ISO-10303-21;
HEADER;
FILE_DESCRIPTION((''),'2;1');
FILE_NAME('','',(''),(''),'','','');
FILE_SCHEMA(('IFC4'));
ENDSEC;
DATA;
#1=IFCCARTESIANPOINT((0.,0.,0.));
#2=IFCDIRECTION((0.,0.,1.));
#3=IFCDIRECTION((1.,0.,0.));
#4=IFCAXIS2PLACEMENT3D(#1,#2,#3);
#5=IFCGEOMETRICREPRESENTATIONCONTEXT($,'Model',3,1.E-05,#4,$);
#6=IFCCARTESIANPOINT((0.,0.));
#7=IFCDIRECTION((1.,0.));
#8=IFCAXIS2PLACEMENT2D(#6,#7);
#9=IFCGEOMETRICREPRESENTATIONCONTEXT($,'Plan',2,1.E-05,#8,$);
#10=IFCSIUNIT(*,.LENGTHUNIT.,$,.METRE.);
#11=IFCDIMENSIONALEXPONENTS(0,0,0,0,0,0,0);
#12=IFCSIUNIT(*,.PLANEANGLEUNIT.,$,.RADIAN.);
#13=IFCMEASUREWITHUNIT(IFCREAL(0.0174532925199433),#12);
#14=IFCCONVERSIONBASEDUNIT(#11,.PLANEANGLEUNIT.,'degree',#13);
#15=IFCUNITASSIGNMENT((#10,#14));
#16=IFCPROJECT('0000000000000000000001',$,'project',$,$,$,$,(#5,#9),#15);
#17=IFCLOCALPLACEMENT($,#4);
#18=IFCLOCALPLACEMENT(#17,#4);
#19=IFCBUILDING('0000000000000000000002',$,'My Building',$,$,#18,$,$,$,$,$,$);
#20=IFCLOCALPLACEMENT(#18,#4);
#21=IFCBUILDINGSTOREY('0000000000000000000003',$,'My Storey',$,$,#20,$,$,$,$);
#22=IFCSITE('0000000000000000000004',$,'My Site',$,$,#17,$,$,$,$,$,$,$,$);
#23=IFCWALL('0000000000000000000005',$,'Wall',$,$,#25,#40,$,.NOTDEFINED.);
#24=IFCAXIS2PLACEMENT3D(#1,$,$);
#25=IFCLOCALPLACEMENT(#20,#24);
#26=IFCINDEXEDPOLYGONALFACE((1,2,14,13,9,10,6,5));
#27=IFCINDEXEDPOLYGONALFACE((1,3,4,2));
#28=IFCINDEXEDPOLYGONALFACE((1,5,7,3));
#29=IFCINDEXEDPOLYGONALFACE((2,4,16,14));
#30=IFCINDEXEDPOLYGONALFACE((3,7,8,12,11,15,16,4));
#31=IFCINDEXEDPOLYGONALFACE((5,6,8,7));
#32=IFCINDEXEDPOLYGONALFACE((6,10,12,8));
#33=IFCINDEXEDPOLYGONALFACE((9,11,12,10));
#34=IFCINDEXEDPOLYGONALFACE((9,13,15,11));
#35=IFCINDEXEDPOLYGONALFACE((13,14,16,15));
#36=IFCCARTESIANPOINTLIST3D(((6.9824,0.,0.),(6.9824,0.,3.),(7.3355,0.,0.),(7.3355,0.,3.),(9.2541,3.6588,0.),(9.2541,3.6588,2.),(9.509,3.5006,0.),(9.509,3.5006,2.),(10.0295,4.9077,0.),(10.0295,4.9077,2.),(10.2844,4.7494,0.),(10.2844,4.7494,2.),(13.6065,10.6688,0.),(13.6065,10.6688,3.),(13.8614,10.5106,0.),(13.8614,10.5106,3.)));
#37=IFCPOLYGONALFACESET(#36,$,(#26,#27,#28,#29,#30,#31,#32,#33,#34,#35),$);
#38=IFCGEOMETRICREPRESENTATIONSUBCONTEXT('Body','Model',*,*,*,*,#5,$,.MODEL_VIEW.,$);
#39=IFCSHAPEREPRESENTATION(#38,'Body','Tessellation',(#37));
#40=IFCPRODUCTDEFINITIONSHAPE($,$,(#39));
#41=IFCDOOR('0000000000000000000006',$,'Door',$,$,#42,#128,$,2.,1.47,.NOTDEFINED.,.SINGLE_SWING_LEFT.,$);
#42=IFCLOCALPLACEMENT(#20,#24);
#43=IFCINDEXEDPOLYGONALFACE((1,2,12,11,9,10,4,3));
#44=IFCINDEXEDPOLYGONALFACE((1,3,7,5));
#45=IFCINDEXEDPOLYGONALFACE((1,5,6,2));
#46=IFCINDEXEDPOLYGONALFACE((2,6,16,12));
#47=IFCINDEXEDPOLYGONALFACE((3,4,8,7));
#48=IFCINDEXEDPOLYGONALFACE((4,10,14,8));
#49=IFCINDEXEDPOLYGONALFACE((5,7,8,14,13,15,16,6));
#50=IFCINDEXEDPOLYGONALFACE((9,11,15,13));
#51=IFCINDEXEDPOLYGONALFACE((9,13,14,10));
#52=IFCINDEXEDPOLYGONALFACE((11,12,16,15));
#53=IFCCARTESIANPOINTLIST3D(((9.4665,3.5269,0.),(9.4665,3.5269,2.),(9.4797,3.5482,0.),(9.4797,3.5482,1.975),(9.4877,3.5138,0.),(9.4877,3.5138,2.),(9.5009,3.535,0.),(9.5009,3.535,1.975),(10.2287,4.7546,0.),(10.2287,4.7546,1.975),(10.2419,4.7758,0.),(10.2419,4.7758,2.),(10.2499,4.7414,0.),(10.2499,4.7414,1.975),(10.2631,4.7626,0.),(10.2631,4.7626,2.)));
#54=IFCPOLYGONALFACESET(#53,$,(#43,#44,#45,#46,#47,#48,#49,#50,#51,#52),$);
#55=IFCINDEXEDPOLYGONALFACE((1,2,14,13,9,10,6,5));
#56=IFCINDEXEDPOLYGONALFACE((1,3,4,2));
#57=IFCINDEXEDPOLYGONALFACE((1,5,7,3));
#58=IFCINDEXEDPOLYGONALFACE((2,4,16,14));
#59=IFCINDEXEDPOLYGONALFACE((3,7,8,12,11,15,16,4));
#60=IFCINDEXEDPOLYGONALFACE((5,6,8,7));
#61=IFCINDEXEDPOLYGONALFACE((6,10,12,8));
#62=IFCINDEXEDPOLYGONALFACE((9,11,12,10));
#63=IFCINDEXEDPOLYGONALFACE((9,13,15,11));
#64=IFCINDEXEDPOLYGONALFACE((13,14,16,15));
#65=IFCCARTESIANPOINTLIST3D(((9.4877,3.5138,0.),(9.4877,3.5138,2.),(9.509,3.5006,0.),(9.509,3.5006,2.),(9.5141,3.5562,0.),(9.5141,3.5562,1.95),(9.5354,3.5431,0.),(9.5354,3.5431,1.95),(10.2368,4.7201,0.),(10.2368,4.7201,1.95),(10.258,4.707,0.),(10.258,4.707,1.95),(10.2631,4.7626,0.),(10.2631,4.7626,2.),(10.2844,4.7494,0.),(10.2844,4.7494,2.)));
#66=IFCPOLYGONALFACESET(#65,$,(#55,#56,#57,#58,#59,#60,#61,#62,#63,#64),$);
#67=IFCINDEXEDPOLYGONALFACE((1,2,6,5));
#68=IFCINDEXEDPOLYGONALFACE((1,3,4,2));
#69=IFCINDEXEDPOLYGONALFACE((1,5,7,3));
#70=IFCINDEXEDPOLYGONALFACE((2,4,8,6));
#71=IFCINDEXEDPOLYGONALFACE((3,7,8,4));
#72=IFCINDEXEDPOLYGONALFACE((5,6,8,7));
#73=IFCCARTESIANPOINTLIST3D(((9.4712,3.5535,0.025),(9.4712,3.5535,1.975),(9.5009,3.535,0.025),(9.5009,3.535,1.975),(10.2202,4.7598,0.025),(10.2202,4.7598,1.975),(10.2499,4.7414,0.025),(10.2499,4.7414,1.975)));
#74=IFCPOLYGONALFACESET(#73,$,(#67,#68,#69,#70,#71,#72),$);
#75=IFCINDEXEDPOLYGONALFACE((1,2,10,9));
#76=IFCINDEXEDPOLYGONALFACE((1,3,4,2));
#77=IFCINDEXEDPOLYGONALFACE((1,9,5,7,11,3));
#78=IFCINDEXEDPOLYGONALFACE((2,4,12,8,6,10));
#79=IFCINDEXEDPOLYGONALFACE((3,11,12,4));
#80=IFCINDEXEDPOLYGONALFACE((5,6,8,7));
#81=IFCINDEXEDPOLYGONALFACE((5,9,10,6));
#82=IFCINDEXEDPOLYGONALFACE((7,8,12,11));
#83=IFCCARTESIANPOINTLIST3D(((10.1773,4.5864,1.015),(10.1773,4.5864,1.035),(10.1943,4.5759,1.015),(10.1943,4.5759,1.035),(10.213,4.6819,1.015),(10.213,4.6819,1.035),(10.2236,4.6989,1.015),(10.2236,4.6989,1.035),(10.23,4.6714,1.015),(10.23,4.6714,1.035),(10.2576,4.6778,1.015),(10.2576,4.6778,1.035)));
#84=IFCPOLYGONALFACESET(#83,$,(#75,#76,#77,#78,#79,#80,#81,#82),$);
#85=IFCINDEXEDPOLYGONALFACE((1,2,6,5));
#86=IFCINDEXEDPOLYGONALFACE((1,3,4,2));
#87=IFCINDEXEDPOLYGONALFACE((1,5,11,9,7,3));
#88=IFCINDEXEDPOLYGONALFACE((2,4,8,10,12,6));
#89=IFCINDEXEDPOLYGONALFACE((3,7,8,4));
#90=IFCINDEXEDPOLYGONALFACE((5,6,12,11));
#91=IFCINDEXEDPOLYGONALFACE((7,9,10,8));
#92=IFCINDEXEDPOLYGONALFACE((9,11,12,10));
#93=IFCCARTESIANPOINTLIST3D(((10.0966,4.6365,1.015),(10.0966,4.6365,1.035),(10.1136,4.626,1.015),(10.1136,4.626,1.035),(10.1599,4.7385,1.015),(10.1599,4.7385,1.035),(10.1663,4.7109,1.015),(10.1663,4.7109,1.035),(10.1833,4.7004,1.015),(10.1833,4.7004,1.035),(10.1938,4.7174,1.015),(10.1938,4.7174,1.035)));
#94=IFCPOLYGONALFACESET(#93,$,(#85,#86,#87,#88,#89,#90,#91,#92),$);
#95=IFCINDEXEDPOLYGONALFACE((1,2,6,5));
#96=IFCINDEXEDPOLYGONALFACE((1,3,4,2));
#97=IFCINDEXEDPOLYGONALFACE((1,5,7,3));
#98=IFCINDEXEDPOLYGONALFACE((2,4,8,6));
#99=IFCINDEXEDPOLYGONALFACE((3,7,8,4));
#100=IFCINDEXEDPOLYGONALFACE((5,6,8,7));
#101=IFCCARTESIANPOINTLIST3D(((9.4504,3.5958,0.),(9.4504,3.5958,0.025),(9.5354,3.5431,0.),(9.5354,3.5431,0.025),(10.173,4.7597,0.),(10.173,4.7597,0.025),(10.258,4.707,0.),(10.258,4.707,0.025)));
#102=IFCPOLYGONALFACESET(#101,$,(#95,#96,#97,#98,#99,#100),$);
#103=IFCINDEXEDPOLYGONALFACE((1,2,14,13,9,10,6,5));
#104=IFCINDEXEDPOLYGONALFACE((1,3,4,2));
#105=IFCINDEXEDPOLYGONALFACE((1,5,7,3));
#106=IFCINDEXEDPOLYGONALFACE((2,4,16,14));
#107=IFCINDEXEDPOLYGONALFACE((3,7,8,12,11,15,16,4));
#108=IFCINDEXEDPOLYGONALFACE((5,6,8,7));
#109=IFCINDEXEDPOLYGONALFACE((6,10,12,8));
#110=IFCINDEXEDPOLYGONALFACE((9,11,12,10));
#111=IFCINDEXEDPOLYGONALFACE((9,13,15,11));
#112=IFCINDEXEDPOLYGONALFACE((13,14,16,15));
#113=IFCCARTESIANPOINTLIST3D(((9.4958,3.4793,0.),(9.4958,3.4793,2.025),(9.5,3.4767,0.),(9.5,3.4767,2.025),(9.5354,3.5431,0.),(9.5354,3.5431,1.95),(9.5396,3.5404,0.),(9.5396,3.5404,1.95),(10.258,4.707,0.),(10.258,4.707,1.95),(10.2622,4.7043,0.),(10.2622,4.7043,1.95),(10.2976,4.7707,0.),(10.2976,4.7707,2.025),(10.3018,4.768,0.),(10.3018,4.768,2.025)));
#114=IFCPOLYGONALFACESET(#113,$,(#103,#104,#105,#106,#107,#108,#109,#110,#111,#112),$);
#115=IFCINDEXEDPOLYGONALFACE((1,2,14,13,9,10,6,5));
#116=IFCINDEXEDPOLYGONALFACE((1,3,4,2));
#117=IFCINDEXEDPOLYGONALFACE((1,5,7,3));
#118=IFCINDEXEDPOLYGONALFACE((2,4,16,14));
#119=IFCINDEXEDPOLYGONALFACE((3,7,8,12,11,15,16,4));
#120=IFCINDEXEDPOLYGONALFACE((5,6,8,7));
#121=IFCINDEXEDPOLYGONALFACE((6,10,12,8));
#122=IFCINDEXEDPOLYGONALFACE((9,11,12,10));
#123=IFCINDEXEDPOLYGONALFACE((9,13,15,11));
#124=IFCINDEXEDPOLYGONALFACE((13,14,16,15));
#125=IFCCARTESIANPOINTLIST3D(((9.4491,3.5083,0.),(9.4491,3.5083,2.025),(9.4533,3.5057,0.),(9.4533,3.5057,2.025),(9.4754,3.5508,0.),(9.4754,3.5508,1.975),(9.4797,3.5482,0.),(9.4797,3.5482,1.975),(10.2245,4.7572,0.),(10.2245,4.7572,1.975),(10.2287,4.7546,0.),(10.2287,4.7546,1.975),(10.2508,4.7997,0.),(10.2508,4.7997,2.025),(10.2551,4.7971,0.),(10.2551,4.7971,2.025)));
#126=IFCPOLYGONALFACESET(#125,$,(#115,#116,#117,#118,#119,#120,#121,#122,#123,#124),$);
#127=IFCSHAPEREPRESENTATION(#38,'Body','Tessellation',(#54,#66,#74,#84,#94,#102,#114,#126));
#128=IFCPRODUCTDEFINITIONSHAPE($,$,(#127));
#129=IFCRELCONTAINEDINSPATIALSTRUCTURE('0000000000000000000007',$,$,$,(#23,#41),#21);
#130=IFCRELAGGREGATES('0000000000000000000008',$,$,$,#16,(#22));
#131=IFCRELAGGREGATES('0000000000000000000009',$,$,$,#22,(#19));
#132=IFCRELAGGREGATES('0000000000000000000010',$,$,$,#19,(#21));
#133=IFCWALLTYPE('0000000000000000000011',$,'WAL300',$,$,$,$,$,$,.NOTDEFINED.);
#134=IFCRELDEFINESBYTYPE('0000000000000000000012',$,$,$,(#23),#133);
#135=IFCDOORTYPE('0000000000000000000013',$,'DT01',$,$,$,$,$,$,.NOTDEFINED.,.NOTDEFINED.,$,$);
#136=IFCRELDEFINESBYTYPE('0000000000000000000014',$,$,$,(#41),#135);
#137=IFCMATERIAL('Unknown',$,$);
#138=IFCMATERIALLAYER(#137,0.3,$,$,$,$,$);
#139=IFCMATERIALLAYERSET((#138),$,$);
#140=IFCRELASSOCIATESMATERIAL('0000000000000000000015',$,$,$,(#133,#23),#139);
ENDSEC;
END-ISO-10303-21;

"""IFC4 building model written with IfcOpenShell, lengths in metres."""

from ifc_helpers import new_model, entity, si_unit, converted_unit, frame, origin_with_axes, origin_2d_with_axis, place, context, subcontext, project, spatial, line, indexed_curve, outline, extrude, clip, halfspace, shape, source, transform, mapped, material, layer, layer_set, layer_usage, type_object, type_shapes, element, fill, save


model = new_model("IFC4")

# Units and contexts
model_context = context("Model", 3, precision=1e-05, world=origin_with_axes())
plan_context = context("Plan", 2, precision=1e-05, world=origin_2d_with_axis())
body_context_1 = subcontext(model_context, "Body", "Model", "MODEL_VIEW")
body_context_2 = subcontext(plan_context, "Body", "Plan", "PLAN_VIEW")
ifc_project = project(units=[si_unit("LENGTHUNIT", "METRE"), converted_unit("PLANEANGLEUNIT", "degree", entity("IfcReal", 0.0174532925199433), si_unit("PLANEANGLEUNIT", "RADIAN"), dimensions=[0, 0, 0, 0, 0, 0, 0])], contexts=[model_context, plan_context])

# Site, building, storey
site_placement = place(None, origin_with_axes())
site = spatial("IfcSite", under=ifc_project, at=site_placement, Name="My Site")
building_placement = place(site_placement, origin_with_axes())
building = spatial("IfcBuilding", under=site, at=building_placement, Name="My Building")
storey_placement = place(building_placement, origin_with_axes())
storey = spatial("IfcBuildingStorey", under=building, at=storey_placement, Name="My Storey")

# Shared definitions
ifc_material = material(Name="Unknown")
ifc_layer = layer(ifc_material, 0.3)
ifc_layer_set = layer_set([ifc_layer])
wall_type = type_object("IfcWallType", Name="WAL300", PredefinedType="NOTDEFINED", material=ifc_layer_set)

# Wall, opening, door
ifc_layer_usage_1 = layer_usage(ifc_layer_set, "AXIS2", "POSITIVE", 0.0)
wall_1_placement = place(storey_placement, frame((7.2373, -0.1582, 0.0), z_axis=(0.0, 0.0, 1.0), x_axis=(0.52748, 0.849568, 0.0)))
wall_1 = element("IfcWall", 1, at=wall_1_placement, inside=storey, type_object=wall_type, material=ifc_layer_usage_1, Name="Wall", PredefinedType="NOTDEFINED", context=body_context_1, shape_type="Clipping", body=[
    clip(extrude(outline(indexed_curve([(0.0, 0.0), (0.0, 0.3), (12.558, 0.3), (12.558, 0.0), (0.0, 0.0)], self_intersect=False)), origin_with_axes(), (0.0, 0.0, 1.0), 3.0), halfspace(frame((0.1863, 0.0, 0.0), z_axis=(-0.900003, -0.558794, 0.0), x_axis=(-0.186265, 0.300001, 0.0)), False)),
])
shared_shape_1 = source(origin_with_axes(), body_context_1, "Body", "SweptSolid", [
    extrude(outline(indexed_curve([(0.0, 0.0, 0.0), (1.47, 0.0, 0.0), (1.47, 0.0, 2.0), (0.0, 0.0, 2.0)], segments=[line(1, 2), line(2, 3), line(3, 4), line(4, 1)])), frame((0.0, -0.1, 0.0), z_axis=(0.0, 0.0, 1.0), x_axis=(1.0, 0.0, 0.0)), (0.0, 1.0, 0.0), 0.5),
])
opening_1_placement = place(wall_1_placement, frame((4.3067, 0.0, 0.0), z_axis=(0.0, 0.0, 1.0), x_axis=(1.0, 0.0, 0.0)))
opening_1 = element("IfcOpeningElement", 2, at=opening_1_placement, cuts=wall_1, PredefinedType="OPENING", context=body_context_1, shape_type="MappedRepresentation", body=[
    mapped(shared_shape_1, transform((0.0, 0.0, 0.0), x_axis=(1.0, 0.0, 0.0), y_axis=(0.0, 1.0, 0.0), z_axis=(0.0, 0.0, 1.0), scale=1.0)),
])
door_type = type_object("IfcDoorType", Name="DT01", OperationType="NOTDEFINED", PredefinedType="NOTDEFINED")
shared_shape_2 = source(origin_with_axes(), body_context_1, "Body", "SweptSolid", [
    extrude(outline(indexed_curve([(0.0, 0.0, 0.0), (0.0, 0.0, 2.0), (1.47, 0.0, 2.0), (1.47, 0.0, 0.0), (1.445, 0.0, 0.0), (1.445, 0.0, 1.975), (0.025, 0.0, 1.975), (0.025, 0.0, 0.0)], segments=[line(1, 2), line(2, 3), line(3, 4), line(4, 5), line(5, 6), line(6, 7), line(7, 8), line(8, 1)])), frame((0.0, 0.025, 0.0), z_axis=(0.0, 0.0, 1.0), x_axis=(1.0, 0.0, 0.0)), (0.0, 1.0, 0.0), 0.025),
    extrude(outline(indexed_curve([(0.0, 0.0, 0.0), (0.0, 0.0, 2.0), (1.47, 0.0, 2.0), (1.47, 0.0, 0.0), (1.42, 0.0, 0.0), (1.42, 0.0, 1.95), (0.05, 0.0, 1.95), (0.05, 0.0, 0.0)], segments=[line(1, 2), line(2, 3), line(3, 4), line(4, 5), line(5, 6), line(6, 7), line(7, 8), line(8, 1)])), origin_with_axes(), (0.0, 1.0, 0.0), 0.025),
    extrude(outline(indexed_curve([(0.0, 0.0), (1.42, 0.0), (1.42, 0.035), (0.0, 0.035)], segments=[line(1, 2), line(2, 3), line(3, 4), line(4, 1)])), frame((0.025, 0.025, 0.025), z_axis=(0.0, 0.0, 1.0), x_axis=(1.0, 0.0, 0.0)), (0.0, 0.0, 1.0), 1.95),
    extrude(outline(indexed_curve([(0.0, 0.0), (0.0, -0.04), (-0.12, -0.04), (-0.12, -0.02), (-0.02, -0.02), (-0.02, 0.0)], segments=[line(1, 2), line(2, 3), line(3, 4), line(4, 5), line(5, 6), line(6, 1)])), frame((1.395, 0.025, 1.015), z_axis=(0.0, 0.0, 1.0), x_axis=(1.0, 0.0, 0.0)), (0.0, 0.0, 1.0), 0.02),
    extrude(outline(indexed_curve([(0.0, 0.0), (0.0, 0.04), (-0.12, 0.04), (-0.12, 0.02), (-0.02, 0.02), (-0.02, 0.0)], segments=[line(1, 2), line(2, 3), line(3, 4), line(4, 5), line(5, 6), line(6, 1)])), frame((1.395, 0.06, 1.015), z_axis=(0.0, 0.0, 1.0), x_axis=(1.0, 0.0, 0.0)), (0.0, 0.0, 1.0), 0.02),
    extrude(outline(indexed_curve([(0.0, 0.0), (1.37, 0.0), (1.37, 0.1), (0.0, 0.1)], segments=[line(1, 2), line(2, 3), line(3, 4), line(4, 1)])), frame((0.05, 0.0, 0.0), z_axis=(0.0, 0.0, 1.0), x_axis=(1.0, 0.0, 0.0)), (0.0, 0.0, 1.0), 0.025),
    extrude(outline(indexed_curve([(0.0, 0.0, 0.0), (0.0, 0.0, 2.025), (1.52, 0.0, 2.025), (1.52, 0.0, 0.0), (1.445, 0.0, 0.0), (1.445, 0.0, 1.95), (0.075, 0.0, 1.95), (0.075, 0.0, 0.0)], segments=[line(1, 2), line(2, 3), line(3, 4), line(4, 5), line(5, 6), line(6, 7), line(7, 8), line(8, 1)])), frame((-0.025, -0.005, 0.0), z_axis=(0.0, 0.0, 1.0), x_axis=(1.0, 0.0, 0.0)), (0.0, 1.0, 0.0), 0.005),
    extrude(outline(indexed_curve([(0.0, 0.0, 0.0), (0.0, 0.0, 2.025), (1.52, 0.0, 2.025), (1.52, 0.0, 0.0), (1.47, 0.0, 0.0), (1.47, 0.0, 1.975), (0.05, 0.0, 1.975), (0.05, 0.0, 0.0)], segments=[line(1, 2), line(2, 3), line(3, 4), line(4, 5), line(5, 6), line(6, 7), line(7, 8), line(8, 1)])), frame((-0.025, 0.05, 0.0), z_axis=(0.0, 0.0, 1.0), x_axis=(1.0, 0.0, 0.0)), (0.0, 1.0, 0.0), 0.005),
])
shared_shape_3 = source(origin_with_axes(), body_context_2, "Body", "Curve2D", [
    entity("IfcIndexedPolyCurve", entity("IfcCartesianPointList2D", [[0.0, 0.0], [0.0, 0.05], [0.025, 0.05], [0.025, 0.025], [0.05, 0.025], [0.05, 0.0]]), [entity("IfcLineIndex", [1, 2]), entity("IfcLineIndex", [2, 3]), entity("IfcLineIndex", [3, 4]), entity("IfcLineIndex", [4, 5]), entity("IfcLineIndex", [5, 6]), entity("IfcLineIndex", [6, 1])]),
    entity("IfcIndexedPolyCurve", entity("IfcCartesianPointList2D", [[1.47, 0.0], [1.47, 0.05], [1.445, 0.05], [1.445, 0.025], [1.42, 0.025], [1.42, 0.0]]), [entity("IfcLineIndex", [1, 2]), entity("IfcLineIndex", [2, 3]), entity("IfcLineIndex", [3, 4]), entity("IfcLineIndex", [4, 5]), entity("IfcLineIndex", [5, 6]), entity("IfcLineIndex", [6, 1])]),
    entity("IfcTrimmedCurve", entity("IfcEllipse", entity("IfcAxis2Placement2D", entity("IfcCartesianPoint", [0.06, 0.05]), entity("IfcDirection", [1.0, 0.0])), 1.385, 1.42), [entity("IfcCartesianPoint", [1.445, 0.05])], [entity("IfcCartesianPoint", [0.06, 1.47])], True, "CARTESIAN"),
    entity("IfcIndexedPolyCurve", entity("IfcCartesianPointList2D", [[0.025, 0.05], [0.06, 0.05], [0.06, 1.47], [0.025, 1.47]]), [entity("IfcLineIndex", [1, 2]), entity("IfcLineIndex", [2, 3]), entity("IfcLineIndex", [3, 4]), entity("IfcLineIndex", [4, 1])]),
])
type_shapes(door_type, [shared_shape_2, shared_shape_3])
door_placement = place(opening_1_placement, frame((0.0, 0.0, 0.0), z_axis=(0.0, 0.0, 1.0), x_axis=(1.0, 0.0, 0.0)))
door = element("IfcDoor", 3, at=door_placement, inside=storey, type_object=door_type, Name="Door", OperationType="SINGLE_SWING_LEFT", OverallHeight=2.0, OverallWidth=1.47, PredefinedType="NOTDEFINED", shapes=[
    shape(body_context_1, "Body", "MappedRepresentation", [mapped(shared_shape_2, transform((0.0, 0.0, 0.0), x_axis=(1.0, 0.0, 0.0), y_axis=(0.0, 1.0, 0.0), z_axis=(0.0, 0.0, 1.0), scale=1.0))]),
    shape(body_context_2, "Body", "MappedRepresentation", [mapped(shared_shape_3, transform((0.0, 0.0, 0.0), x_axis=(1.0, 0.0, 0.0), y_axis=(0.0, 1.0, 0.0), z_axis=(0.0, 0.0, 1.0), scale=1.0))]),
])
fill(opening_1, door)

save(model, "model.ifc")
